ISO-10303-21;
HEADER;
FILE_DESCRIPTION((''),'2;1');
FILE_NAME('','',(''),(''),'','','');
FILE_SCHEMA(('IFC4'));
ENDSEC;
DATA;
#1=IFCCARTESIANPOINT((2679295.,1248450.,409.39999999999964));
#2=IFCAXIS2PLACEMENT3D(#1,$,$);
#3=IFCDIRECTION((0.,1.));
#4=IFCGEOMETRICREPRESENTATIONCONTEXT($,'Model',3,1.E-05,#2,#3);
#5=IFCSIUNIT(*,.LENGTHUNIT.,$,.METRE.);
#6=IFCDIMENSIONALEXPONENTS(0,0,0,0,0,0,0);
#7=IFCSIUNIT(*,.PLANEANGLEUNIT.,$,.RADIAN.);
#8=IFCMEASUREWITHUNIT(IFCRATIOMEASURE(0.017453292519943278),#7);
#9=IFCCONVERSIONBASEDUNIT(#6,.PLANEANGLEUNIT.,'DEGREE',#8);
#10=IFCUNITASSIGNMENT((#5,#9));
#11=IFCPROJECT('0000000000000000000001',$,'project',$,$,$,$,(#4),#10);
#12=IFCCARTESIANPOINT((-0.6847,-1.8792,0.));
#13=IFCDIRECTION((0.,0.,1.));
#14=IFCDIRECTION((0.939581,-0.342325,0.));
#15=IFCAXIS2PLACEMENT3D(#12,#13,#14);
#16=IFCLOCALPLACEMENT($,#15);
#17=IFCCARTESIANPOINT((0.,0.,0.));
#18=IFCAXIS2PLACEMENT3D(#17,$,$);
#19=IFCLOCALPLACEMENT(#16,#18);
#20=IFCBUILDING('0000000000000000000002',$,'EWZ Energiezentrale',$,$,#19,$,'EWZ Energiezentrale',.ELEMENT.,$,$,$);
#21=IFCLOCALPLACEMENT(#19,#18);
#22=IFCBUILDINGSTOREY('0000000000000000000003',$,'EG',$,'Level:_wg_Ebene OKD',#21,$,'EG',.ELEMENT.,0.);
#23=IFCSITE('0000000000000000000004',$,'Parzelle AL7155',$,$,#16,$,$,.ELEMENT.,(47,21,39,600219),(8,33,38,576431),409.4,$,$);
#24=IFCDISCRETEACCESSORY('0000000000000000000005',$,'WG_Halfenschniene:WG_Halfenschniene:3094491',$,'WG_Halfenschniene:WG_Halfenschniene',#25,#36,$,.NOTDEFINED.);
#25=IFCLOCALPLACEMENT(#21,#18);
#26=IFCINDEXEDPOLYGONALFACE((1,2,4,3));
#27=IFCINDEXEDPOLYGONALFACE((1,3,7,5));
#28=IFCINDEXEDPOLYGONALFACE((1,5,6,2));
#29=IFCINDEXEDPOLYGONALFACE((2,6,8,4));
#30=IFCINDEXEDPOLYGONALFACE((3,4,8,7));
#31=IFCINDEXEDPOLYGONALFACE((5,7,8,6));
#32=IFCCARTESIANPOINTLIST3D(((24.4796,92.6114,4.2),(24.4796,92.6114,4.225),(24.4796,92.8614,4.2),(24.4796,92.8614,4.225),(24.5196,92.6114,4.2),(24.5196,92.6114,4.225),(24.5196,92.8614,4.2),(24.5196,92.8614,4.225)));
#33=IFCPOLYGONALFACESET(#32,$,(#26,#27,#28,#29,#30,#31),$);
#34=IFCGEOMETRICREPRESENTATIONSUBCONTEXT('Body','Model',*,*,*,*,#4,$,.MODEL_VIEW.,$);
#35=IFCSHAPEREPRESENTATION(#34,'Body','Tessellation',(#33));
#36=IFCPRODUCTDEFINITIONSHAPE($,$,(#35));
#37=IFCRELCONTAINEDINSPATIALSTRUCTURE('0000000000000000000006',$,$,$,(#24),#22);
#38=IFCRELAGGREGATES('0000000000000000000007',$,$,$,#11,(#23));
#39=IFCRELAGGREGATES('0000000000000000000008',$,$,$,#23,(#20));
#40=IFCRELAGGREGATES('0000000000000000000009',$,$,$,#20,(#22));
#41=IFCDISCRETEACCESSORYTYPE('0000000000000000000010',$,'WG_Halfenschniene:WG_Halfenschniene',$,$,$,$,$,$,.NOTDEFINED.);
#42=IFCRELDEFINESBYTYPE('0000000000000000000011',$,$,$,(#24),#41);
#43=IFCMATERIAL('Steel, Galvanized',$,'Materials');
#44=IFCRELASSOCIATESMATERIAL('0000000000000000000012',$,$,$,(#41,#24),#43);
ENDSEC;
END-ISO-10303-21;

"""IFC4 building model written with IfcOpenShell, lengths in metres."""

from ifc_helpers import new_model, entity, si_unit, converted_unit, direction, frame, origin, place, context, subcontext, project, spatial, indexed_curve, outline, extrude, source, transform, mapped, material, type_object, element, save


model = new_model("IFC4")

# Units and contexts
model_context = context("Model", 3, precision=1e-05, world=frame((2679295.0, 1248450.0, 409.39999999999964)), true_north=direction((0.0, 1.0)))
body_context = subcontext(model_context, "Body", "Model", "MODEL_VIEW")
ifc_project = project(units=[si_unit("LENGTHUNIT", "METRE"), converted_unit("PLANEANGLEUNIT", "DEGREE", entity("IfcRatioMeasure", 0.017453292519943278), si_unit("PLANEANGLEUNIT", "RADIAN"), dimensions=[0, 0, 0, 0, 0, 0, 0])], contexts=[model_context])

# Site, building, storey
site_placement = place(None, frame((-0.6847, -1.8792, 0.0), z_axis=(0.0, 0.0, 1.0), x_axis=(0.939581, -0.342325, 0.0)))
site = spatial("IfcSite", under=ifc_project, at=site_placement, Name="Parzelle AL7155", CompositionType="ELEMENT", RefLatitude=(47, 21, 39, 600219), RefLongitude=(8, 33, 38, 576431), RefElevation=409.4)
building_placement = place(site_placement, origin())
building = spatial("IfcBuilding", under=site, at=building_placement, Name="EWZ Energiezentrale", LongName="EWZ Energiezentrale", CompositionType="ELEMENT")
storey_placement = place(building_placement, origin())
storey = spatial("IfcBuildingStorey", under=building, at=storey_placement, Name="EG", ObjectType="Level:_wg_Ebene OKD", LongName="EG", CompositionType="ELEMENT", Elevation=0.0)

# Discrete accessory
ifc_material = material(Name="Steel, Galvanized", Category="Materials")
discrete_accessory_type = type_object("IfcDiscreteAccessoryType", Name="WG_Halfenschniene:WG_Halfenschniene", PredefinedType="NOTDEFINED", material=ifc_material)
shared_shape = source(origin(), body_context, "Body", "SweptSolid", [
    extrude(outline(indexed_curve([(-0.125, -0.02), (0.125, -0.02), (0.125, 0.02), (-0.125, 0.02), (-0.125, -0.02)], self_intersect=False)), frame((0.125, 0.0, -0.0125)), (0.0, 0.0, 1.0), 0.025),
])
for number, where, z_axis, x_axis, name in (
    (1, (24.4996, 92.6114, 4.2125), (0.0, 0.0, -1.0), (0.0, 1.0, 0.0), "WG_Halfenschniene:WG_Halfenschniene:3094491"),
):
    element("IfcDiscreteAccessory", number, at=place(storey_placement, frame(where, z_axis=z_axis, x_axis=x_axis)), inside=storey, type_object=discrete_accessory_type, material=ifc_material, Name=name, ObjectType="WG_Halfenschniene:WG_Halfenschniene", PredefinedType="NOTDEFINED", context=body_context, shape_type="MappedRepresentation", body=[
        mapped(shared_shape, transform((0.0, 0.0, 0.0), scale=1.0)),
    ])

save(model, "model.ifc")
